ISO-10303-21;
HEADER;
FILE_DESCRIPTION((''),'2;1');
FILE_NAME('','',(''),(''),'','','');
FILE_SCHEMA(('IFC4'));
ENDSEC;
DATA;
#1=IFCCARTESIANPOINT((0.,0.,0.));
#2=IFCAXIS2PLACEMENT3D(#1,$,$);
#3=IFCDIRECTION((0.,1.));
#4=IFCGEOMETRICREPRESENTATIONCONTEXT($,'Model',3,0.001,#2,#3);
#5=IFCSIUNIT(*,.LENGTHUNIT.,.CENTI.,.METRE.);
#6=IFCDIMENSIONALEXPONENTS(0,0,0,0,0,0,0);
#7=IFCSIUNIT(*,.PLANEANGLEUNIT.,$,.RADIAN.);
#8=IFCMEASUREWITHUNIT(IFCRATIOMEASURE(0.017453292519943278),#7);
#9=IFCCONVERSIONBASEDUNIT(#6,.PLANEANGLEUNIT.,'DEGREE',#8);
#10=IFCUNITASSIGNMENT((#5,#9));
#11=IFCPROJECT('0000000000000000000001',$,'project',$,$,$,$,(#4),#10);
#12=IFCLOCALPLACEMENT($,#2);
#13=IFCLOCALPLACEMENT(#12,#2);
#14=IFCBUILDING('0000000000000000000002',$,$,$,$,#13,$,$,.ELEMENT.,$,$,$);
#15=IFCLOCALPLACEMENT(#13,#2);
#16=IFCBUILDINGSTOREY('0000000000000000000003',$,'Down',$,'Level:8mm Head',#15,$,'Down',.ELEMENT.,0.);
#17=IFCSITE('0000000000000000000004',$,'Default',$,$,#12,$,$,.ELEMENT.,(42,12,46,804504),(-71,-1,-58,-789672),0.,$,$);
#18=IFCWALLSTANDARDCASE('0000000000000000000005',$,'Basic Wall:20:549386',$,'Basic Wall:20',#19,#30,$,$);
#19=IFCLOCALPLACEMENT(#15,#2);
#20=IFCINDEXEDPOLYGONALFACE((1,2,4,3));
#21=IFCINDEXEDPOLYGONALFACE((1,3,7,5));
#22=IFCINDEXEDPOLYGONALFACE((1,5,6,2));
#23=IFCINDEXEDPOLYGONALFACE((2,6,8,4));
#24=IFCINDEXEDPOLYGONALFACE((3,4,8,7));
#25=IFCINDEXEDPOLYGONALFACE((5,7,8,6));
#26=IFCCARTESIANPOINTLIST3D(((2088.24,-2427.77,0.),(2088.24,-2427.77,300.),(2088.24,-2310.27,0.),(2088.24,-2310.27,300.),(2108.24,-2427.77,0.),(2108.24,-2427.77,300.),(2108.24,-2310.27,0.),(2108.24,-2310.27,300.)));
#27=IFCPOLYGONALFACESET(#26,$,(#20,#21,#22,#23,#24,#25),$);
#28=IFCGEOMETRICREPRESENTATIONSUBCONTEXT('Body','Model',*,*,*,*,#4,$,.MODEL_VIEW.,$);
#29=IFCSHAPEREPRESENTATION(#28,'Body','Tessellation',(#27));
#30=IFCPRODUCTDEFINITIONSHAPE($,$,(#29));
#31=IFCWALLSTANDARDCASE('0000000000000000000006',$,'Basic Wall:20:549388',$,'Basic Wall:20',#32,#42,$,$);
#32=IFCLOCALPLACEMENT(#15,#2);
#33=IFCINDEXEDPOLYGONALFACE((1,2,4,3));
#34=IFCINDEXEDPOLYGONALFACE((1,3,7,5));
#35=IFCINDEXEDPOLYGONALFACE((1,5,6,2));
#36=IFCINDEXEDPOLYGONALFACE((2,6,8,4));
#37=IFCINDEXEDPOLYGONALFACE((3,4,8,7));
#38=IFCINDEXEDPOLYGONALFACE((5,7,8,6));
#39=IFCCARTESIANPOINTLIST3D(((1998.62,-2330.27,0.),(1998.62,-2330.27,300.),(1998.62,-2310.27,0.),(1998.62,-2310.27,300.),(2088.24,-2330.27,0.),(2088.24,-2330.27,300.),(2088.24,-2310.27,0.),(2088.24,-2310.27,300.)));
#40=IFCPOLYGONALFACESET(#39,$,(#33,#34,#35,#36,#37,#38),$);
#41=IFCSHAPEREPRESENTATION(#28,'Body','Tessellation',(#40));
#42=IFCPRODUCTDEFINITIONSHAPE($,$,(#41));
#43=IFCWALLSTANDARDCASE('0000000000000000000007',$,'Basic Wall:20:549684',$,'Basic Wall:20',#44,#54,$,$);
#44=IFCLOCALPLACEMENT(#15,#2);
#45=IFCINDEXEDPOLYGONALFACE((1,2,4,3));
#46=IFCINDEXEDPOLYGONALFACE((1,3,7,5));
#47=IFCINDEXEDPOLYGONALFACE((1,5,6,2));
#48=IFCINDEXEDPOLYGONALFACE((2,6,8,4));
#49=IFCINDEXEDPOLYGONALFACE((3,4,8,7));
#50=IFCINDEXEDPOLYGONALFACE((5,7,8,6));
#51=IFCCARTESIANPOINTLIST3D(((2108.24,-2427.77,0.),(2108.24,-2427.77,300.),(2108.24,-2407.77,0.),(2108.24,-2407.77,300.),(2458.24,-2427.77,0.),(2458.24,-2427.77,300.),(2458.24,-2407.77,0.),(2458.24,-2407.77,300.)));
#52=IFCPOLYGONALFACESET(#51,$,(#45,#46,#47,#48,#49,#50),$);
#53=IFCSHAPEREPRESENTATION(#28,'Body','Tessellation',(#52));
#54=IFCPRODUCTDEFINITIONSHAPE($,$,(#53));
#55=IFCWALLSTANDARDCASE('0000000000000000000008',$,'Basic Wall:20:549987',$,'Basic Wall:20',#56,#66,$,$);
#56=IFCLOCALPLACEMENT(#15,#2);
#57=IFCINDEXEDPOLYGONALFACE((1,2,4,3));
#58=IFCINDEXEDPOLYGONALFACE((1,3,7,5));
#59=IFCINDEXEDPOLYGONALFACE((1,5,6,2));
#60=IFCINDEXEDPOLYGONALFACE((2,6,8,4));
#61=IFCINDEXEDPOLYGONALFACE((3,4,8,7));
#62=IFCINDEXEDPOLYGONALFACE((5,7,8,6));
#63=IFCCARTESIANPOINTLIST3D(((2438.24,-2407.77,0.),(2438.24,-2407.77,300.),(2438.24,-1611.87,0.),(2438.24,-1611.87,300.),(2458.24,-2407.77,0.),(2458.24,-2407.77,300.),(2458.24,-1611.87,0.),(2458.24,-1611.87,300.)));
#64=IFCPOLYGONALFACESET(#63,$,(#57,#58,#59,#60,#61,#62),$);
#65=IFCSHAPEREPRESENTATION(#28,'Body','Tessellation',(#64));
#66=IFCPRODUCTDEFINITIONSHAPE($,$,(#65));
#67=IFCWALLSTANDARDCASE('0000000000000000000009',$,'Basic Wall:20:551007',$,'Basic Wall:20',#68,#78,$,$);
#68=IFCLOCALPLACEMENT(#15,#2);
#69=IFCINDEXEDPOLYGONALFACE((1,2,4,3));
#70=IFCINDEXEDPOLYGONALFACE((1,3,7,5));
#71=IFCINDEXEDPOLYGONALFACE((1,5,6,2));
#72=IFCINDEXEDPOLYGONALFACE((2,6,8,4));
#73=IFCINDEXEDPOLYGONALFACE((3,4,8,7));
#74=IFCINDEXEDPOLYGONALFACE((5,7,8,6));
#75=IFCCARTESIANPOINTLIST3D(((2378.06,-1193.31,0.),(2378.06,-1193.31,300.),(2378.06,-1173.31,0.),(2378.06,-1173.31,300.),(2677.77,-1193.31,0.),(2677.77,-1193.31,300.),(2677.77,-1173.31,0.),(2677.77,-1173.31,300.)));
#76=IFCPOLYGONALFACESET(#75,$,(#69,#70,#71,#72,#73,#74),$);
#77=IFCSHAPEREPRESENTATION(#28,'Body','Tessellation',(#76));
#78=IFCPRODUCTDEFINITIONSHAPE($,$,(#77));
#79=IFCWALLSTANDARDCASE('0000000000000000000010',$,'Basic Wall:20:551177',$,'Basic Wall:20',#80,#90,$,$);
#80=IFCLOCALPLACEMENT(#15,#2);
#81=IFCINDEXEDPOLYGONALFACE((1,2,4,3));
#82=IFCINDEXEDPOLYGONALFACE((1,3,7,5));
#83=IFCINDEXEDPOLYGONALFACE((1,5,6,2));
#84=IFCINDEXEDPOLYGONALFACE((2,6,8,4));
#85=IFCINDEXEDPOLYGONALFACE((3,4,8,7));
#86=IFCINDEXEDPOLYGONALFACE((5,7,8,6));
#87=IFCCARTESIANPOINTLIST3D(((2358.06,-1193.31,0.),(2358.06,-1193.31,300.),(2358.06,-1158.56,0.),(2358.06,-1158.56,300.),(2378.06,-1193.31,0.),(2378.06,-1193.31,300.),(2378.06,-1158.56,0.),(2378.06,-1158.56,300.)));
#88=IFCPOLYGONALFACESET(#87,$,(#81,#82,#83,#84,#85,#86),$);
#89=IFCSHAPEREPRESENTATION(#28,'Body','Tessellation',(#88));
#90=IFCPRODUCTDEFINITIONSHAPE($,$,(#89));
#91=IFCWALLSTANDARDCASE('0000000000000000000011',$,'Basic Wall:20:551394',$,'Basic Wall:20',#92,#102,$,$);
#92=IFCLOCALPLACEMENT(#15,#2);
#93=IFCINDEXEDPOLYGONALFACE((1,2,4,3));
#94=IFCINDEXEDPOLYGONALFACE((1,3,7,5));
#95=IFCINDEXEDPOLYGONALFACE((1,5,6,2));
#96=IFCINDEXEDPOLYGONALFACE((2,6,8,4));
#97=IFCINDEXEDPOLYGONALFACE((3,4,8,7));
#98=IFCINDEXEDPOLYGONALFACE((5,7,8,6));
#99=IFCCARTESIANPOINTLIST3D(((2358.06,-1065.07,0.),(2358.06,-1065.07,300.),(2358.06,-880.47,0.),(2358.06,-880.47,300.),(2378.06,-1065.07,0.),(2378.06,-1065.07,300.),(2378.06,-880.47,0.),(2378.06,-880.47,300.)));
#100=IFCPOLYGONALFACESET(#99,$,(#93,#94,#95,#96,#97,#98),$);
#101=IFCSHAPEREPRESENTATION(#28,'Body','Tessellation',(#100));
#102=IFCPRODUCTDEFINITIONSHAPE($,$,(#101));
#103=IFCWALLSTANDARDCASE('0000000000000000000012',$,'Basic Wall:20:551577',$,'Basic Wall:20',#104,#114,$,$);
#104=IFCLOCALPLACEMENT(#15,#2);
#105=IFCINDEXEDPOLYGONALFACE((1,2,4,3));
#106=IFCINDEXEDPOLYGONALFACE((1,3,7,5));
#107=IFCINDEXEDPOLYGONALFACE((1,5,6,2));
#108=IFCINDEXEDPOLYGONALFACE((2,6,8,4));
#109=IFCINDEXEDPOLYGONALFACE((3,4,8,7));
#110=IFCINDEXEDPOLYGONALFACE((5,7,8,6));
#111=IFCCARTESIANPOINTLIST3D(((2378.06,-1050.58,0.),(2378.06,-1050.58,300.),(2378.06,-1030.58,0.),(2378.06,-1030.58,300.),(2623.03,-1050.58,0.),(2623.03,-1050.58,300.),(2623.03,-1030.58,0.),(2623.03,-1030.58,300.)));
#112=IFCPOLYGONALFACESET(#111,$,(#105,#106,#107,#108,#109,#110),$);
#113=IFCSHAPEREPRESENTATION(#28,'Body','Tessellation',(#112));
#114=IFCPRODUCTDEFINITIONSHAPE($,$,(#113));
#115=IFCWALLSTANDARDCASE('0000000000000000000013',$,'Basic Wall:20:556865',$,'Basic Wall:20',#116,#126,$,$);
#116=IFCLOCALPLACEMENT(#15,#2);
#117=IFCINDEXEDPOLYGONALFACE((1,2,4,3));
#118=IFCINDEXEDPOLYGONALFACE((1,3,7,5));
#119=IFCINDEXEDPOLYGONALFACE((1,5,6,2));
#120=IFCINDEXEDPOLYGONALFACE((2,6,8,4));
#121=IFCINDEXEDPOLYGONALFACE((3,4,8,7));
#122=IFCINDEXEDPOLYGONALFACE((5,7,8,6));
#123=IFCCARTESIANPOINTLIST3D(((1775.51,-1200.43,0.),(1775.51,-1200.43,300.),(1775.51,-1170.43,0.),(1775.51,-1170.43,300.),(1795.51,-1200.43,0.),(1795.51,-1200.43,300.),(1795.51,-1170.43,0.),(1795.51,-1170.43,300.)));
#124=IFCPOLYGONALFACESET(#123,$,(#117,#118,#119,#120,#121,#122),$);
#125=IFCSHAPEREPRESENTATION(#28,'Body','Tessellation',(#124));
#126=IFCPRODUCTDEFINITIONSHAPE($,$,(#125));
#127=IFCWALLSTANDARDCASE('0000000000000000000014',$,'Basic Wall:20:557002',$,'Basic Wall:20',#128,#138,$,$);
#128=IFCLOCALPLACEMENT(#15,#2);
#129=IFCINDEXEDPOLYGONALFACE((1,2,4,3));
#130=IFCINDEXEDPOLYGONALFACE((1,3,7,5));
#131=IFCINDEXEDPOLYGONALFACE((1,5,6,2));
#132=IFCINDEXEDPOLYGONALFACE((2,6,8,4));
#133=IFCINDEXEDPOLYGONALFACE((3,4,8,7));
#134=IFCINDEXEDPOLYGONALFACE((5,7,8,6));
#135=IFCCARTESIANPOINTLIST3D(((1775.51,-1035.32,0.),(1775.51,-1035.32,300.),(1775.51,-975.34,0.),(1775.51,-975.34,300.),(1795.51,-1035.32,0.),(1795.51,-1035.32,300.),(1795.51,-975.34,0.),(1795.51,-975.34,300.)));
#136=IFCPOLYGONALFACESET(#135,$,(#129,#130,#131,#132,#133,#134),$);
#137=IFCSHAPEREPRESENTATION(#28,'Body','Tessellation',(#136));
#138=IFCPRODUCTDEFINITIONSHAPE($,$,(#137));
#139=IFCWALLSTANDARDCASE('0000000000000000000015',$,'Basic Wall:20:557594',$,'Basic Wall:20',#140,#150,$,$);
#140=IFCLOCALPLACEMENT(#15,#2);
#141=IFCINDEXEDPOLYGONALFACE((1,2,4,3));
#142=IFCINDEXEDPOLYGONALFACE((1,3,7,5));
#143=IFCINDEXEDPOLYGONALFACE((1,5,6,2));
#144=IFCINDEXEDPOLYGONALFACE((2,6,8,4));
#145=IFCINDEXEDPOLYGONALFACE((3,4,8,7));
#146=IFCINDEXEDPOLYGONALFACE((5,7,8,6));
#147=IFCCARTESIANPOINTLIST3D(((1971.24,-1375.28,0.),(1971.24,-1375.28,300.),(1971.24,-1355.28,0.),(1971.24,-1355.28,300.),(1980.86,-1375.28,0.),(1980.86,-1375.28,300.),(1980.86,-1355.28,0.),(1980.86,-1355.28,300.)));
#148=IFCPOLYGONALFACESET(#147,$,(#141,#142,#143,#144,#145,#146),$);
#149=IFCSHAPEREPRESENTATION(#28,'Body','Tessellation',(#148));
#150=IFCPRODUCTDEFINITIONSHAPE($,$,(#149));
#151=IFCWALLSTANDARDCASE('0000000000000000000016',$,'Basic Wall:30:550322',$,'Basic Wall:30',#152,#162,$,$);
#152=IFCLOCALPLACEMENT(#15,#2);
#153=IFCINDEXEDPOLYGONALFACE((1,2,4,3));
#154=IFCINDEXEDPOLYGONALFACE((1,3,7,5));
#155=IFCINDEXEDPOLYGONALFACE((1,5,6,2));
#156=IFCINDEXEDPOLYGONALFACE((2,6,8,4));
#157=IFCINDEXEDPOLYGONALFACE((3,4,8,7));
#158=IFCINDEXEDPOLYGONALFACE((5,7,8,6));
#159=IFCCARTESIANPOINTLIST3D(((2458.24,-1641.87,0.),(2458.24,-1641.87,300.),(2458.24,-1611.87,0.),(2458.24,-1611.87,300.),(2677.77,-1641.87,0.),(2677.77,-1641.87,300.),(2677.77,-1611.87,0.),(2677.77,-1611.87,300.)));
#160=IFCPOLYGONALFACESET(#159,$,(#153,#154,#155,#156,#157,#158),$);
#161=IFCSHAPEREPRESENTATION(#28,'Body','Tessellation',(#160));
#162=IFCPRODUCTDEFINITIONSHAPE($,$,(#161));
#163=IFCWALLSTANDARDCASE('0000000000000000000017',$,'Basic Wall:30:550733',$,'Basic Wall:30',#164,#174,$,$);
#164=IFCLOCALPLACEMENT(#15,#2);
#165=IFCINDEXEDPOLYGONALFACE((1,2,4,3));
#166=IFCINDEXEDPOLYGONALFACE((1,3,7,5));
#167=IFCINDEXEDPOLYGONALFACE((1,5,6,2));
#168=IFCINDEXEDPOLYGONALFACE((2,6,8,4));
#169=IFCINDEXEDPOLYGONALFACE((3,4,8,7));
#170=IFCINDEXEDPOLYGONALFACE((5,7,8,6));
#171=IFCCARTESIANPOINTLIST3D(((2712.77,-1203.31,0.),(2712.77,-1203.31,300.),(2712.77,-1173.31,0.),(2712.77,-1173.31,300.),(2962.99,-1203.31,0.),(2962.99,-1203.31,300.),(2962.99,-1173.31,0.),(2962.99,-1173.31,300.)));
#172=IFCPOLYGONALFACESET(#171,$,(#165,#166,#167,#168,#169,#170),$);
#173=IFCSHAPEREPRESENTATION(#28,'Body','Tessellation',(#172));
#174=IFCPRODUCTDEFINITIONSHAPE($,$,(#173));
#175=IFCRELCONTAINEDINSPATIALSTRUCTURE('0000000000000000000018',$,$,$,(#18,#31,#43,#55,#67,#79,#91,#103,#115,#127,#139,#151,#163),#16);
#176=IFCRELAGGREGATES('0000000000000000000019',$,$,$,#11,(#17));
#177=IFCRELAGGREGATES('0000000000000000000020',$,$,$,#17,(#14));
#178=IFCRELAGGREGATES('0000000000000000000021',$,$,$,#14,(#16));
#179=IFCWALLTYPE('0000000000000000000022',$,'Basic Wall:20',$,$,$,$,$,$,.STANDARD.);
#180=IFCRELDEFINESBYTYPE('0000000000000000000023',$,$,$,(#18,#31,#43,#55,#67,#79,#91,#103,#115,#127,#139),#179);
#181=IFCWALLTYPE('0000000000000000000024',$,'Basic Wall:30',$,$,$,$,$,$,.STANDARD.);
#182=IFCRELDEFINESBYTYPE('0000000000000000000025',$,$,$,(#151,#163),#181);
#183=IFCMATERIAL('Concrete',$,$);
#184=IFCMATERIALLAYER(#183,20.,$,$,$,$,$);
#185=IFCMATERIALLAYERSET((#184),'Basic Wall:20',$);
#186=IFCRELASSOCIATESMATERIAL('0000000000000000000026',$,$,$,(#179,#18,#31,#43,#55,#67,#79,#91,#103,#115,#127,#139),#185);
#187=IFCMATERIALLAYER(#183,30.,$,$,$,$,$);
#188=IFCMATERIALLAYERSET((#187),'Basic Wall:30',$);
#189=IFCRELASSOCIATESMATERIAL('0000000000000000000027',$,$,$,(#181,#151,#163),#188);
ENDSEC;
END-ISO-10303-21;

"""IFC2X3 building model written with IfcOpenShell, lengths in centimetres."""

from ifc_helpers import new_model, entity, si_unit, converted_unit, direction, frame, frame_2d, origin, place, context, subcontext, project, spatial, rectangle, extrude, material, layer, layer_set, layer_usage, type_object, element, save


model = new_model("IFC2X3")

# Units and contexts
model_context = context("Model", 3, precision=0.001, world=origin(), true_north=direction((0.0, 1.0)))
body_context = subcontext(model_context, "Body", "Model", "MODEL_VIEW")
ifc_project = project(units=[si_unit("LENGTHUNIT", "METRE", prefix="CENTI"), converted_unit("PLANEANGLEUNIT", "DEGREE", entity("IfcRatioMeasure", 0.017453292519943278), si_unit("PLANEANGLEUNIT", "RADIAN"), dimensions=[0, 0, 0, 0, 0, 0, 0])], contexts=[model_context])

# Site, building, storey
site_placement = place(None, origin())
site = spatial("IfcSite", under=ifc_project, at=site_placement, Name="Default", CompositionType="ELEMENT", RefLatitude=(42, 12, 46, 804504), RefLongitude=(-71, -1, -58, -789672), RefElevation=0.0)
building_placement = place(site_placement, origin())
building = spatial("IfcBuilding", under=site, at=building_placement, CompositionType="ELEMENT")
storey_placement = place(building_placement, origin())
storey = spatial("IfcBuildingStorey", under=building, at=storey_placement, Name="Down", ObjectType="Level:8mm Head", LongName="Down", CompositionType="ELEMENT", Elevation=0.0)

# Walls
ifc_material = material(Name="Concrete")
ifc_layer_1 = layer(ifc_material, 20.0)
ifc_layer_set_1 = layer_set([ifc_layer_1], Name="Basic Wall:20")
ifc_layer_usage_1 = layer_usage(ifc_layer_set_1, "AXIS2", "NEGATIVE", 10.0)
wall_type_1 = type_object("IfcWallType", Name="Basic Wall:20", PredefinedType="STANDARD", material=ifc_layer_set_1)
wall_1_placement = place(storey_placement, frame((2098.24, -2427.77, 0.0), z_axis=(0.0, 0.0, 1.0), x_axis=(0.0, 1.0, 0.0)))
element("IfcWallStandardCase", 1, at=wall_1_placement, inside=storey, type_object=wall_type_1, material=ifc_layer_usage_1, Name="Basic Wall:20:549386", ObjectType="Basic Wall:20", context=body_context, shape_type="SweptSolid", body=[
    extrude(rectangle(XDim=117.5, YDim=20.0, at=frame_2d((58.75, 0.0), x_axis=(-1.0, 0.0))), origin(), (0.0, 0.0, 1.0), 300.0),
])
ifc_layer_usage_2 = layer_usage(ifc_layer_set_1, "AXIS2", "POSITIVE", -10.0)
wall_2_placement = place(storey_placement, frame((2088.24, -2320.27, 0.0), z_axis=(0.0, 0.0, 1.0), x_axis=(-1.0, 0.0, 0.0)))
element("IfcWallStandardCase", 2, at=wall_2_placement, inside=storey, type_object=wall_type_1, material=ifc_layer_usage_2, Name="Basic Wall:20:549388", ObjectType="Basic Wall:20", context=body_context, shape_type="SweptSolid", body=[
    extrude(rectangle(XDim=89.62, YDim=20.0, at=frame_2d((44.81, 0.0), x_axis=(-1.0, 0.0))), origin(), (0.0, 0.0, 1.0), 300.0),
])
ifc_layer_usage_3 = layer_usage(ifc_layer_set_1, "AXIS2", "POSITIVE", -10.0)
wall_3_placement = place(storey_placement, frame((2108.24, -2417.77, 0.0)))
element("IfcWallStandardCase", 3, at=wall_3_placement, inside=storey, type_object=wall_type_1, material=ifc_layer_usage_3, Name="Basic Wall:20:549684", ObjectType="Basic Wall:20", context=body_context, shape_type="SweptSolid", body=[
    extrude(rectangle(XDim=350.0, YDim=20.0, at=frame_2d((175.0, 0.0), x_axis=(-1.0, 0.0))), origin(), (0.0, 0.0, 1.0), 300.0),
])
ifc_layer_usage_4 = layer_usage(ifc_layer_set_1, "AXIS2", "POSITIVE", -10.0)
wall_4_placement = place(storey_placement, frame((2448.24, -2407.77, 0.0), z_axis=(0.0, 0.0, 1.0), x_axis=(0.0, 1.0, 0.0)))
element("IfcWallStandardCase", 4, at=wall_4_placement, inside=storey, type_object=wall_type_1, material=ifc_layer_usage_4, Name="Basic Wall:20:549987", ObjectType="Basic Wall:20", context=body_context, shape_type="SweptSolid", body=[
    extrude(rectangle(XDim=795.9, YDim=20.0, at=frame_2d((397.95, 0.0), x_axis=(-1.0, 0.0))), origin(), (0.0, 0.0, 1.0), 300.0),
])
ifc_layer_usage_5 = layer_usage(ifc_layer_set_1, "AXIS2", "POSITIVE", -10.0)
wall_5_placement = place(storey_placement, frame((2677.77, -1183.31, 0.0), z_axis=(0.0, 0.0, 1.0), x_axis=(-1.0, 0.0, 0.0)))
element("IfcWallStandardCase", 5, at=wall_5_placement, inside=storey, type_object=wall_type_1, material=ifc_layer_usage_5, Name="Basic Wall:20:551007", ObjectType="Basic Wall:20", context=body_context, shape_type="SweptSolid", body=[
    extrude(rectangle(XDim=299.7, YDim=20.0, at=frame_2d((149.85, 0.0), x_axis=(-1.0, 0.0))), origin(), (0.0, 0.0, 1.0), 300.0),
])
ifc_layer_usage_6 = layer_usage(ifc_layer_set_1, "AXIS2", "NEGATIVE", 10.0)
wall_6_placement = place(storey_placement, frame((2368.06, -1193.31, 0.0), z_axis=(0.0, 0.0, 1.0), x_axis=(0.0, 1.0, 0.0)))
element("IfcWallStandardCase", 6, at=wall_6_placement, inside=storey, type_object=wall_type_1, material=ifc_layer_usage_6, Name="Basic Wall:20:551177", ObjectType="Basic Wall:20", context=body_context, shape_type="SweptSolid", body=[
    extrude(rectangle(XDim=34.74, YDim=20.0, at=frame_2d((17.37, 0.0), x_axis=(-1.0, 0.0))), origin(), (0.0, 0.0, 1.0), 300.0),
])
ifc_layer_usage_7 = layer_usage(ifc_layer_set_1, "AXIS2", "NEGATIVE", 10.0)
wall_7_placement = place(storey_placement, frame((2368.06, -1065.07, 0.0), z_axis=(0.0, 0.0, 1.0), x_axis=(0.0, 1.0, 0.0)))
element("IfcWallStandardCase", 7, at=wall_7_placement, inside=storey, type_object=wall_type_1, material=ifc_layer_usage_7, Name="Basic Wall:20:551394", ObjectType="Basic Wall:20", context=body_context, shape_type="SweptSolid", body=[
    extrude(rectangle(XDim=184.6, YDim=20.0, at=frame_2d((92.3, 0.0), x_axis=(-1.0, 0.0))), origin(), (0.0, 0.0, 1.0), 300.0),
])
ifc_layer_usage_8 = layer_usage(ifc_layer_set_1, "AXIS2", "POSITIVE", -10.0)
wall_8_placement = place(storey_placement, frame((2378.06, -1040.58, 0.0)))
element("IfcWallStandardCase", 8, at=wall_8_placement, inside=storey, type_object=wall_type_1, material=ifc_layer_usage_8, Name="Basic Wall:20:551577", ObjectType="Basic Wall:20", context=body_context, shape_type="SweptSolid", body=[
    extrude(rectangle(XDim=244.97, YDim=20.0, at=frame_2d((122.48, 0.0), x_axis=(-1.0, 0.0))), origin(), (0.0, 0.0, 1.0), 300.0),
])
ifc_layer_usage_9 = layer_usage(ifc_layer_set_1, "AXIS2", "POSITIVE", -10.0)
wall_9_placement = place(storey_placement, frame((1785.51, -1200.43, 0.0), z_axis=(0.0, 0.0, 1.0), x_axis=(0.0, 1.0, 0.0)))
element("IfcWallStandardCase", 9, at=wall_9_placement, inside=storey, type_object=wall_type_1, material=ifc_layer_usage_9, Name="Basic Wall:20:556865", ObjectType="Basic Wall:20", context=body_context, shape_type="SweptSolid", body=[
    extrude(rectangle(XDim=30.0, YDim=20.0, at=frame_2d((15.0, 0.0), x_axis=(-1.0, 0.0))), origin(), (0.0, 0.0, 1.0), 300.0),
])
ifc_layer_usage_10 = layer_usage(ifc_layer_set_1, "AXIS2", "NEGATIVE", 10.0)
wall_10_placement = place(storey_placement, frame((1785.51, -975.34, 0.0), z_axis=(0.0, 0.0, 1.0), x_axis=(0.0, -1.0, 0.0)))
element("IfcWallStandardCase", 10, at=wall_10_placement, inside=storey, type_object=wall_type_1, material=ifc_layer_usage_10, Name="Basic Wall:20:557002", ObjectType="Basic Wall:20", context=body_context, shape_type="SweptSolid", body=[
    extrude(rectangle(XDim=59.98, YDim=20.0, at=frame_2d((29.99, 0.0), x_axis=(-1.0, 0.0))), origin(), (0.0, 0.0, 1.0), 300.0),
])
ifc_layer_usage_11 = layer_usage(ifc_layer_set_1, "AXIS2", "POSITIVE", -10.0)
wall_11_placement = place(storey_placement, frame((1971.24, -1365.28, 0.0)))
element("IfcWallStandardCase", 11, at=wall_11_placement, inside=storey, type_object=wall_type_1, material=ifc_layer_usage_11, Name="Basic Wall:20:557594", ObjectType="Basic Wall:20", context=body_context, shape_type="SweptSolid", body=[
    extrude(rectangle(XDim=9.62, YDim=20.0, at=frame_2d((4.81, 0.0), x_axis=(-1.0, 0.0))), origin(), (0.0, 0.0, 1.0), 300.0),
])
ifc_layer_2 = layer(ifc_material, 30.0)
ifc_layer_set_2 = layer_set([ifc_layer_2], Name="Basic Wall:30")
ifc_layer_usage_12 = layer_usage(ifc_layer_set_2, "AXIS2", "NEGATIVE", 15.0)
wall_type_2 = type_object("IfcWallType", Name="Basic Wall:30", PredefinedType="STANDARD", material=ifc_layer_set_2)
wall_12_placement = place(storey_placement, frame((2458.24, -1626.87, 0.0)))
element("IfcWallStandardCase", 12, at=wall_12_placement, inside=storey, type_object=wall_type_2, material=ifc_layer_usage_12, Name="Basic Wall:30:550322", ObjectType="Basic Wall:30", context=body_context, shape_type="SweptSolid", body=[
    extrude(rectangle(XDim=219.52, YDim=30.0, at=frame_2d((109.76, 0.0), x_axis=(-1.0, 0.0))), origin(), (0.0, 0.0, 1.0), 300.0),
])
ifc_layer_usage_13 = layer_usage(ifc_layer_set_2, "AXIS2", "NEGATIVE", 15.0)
wall_13_placement = place(storey_placement, frame((2712.77, -1188.31, 0.0)))
element("IfcWallStandardCase", 13, at=wall_13_placement, inside=storey, type_object=wall_type_2, material=ifc_layer_usage_13, Name="Basic Wall:30:550733", ObjectType="Basic Wall:30", context=body_context, shape_type="SweptSolid", body=[
    extrude(rectangle(XDim=250.23, YDim=30.0, at=frame_2d((125.11, 0.0), x_axis=(-1.0, 0.0))), origin(), (0.0, 0.0, 1.0), 300.0),
])

save(model, "model.ifc")
